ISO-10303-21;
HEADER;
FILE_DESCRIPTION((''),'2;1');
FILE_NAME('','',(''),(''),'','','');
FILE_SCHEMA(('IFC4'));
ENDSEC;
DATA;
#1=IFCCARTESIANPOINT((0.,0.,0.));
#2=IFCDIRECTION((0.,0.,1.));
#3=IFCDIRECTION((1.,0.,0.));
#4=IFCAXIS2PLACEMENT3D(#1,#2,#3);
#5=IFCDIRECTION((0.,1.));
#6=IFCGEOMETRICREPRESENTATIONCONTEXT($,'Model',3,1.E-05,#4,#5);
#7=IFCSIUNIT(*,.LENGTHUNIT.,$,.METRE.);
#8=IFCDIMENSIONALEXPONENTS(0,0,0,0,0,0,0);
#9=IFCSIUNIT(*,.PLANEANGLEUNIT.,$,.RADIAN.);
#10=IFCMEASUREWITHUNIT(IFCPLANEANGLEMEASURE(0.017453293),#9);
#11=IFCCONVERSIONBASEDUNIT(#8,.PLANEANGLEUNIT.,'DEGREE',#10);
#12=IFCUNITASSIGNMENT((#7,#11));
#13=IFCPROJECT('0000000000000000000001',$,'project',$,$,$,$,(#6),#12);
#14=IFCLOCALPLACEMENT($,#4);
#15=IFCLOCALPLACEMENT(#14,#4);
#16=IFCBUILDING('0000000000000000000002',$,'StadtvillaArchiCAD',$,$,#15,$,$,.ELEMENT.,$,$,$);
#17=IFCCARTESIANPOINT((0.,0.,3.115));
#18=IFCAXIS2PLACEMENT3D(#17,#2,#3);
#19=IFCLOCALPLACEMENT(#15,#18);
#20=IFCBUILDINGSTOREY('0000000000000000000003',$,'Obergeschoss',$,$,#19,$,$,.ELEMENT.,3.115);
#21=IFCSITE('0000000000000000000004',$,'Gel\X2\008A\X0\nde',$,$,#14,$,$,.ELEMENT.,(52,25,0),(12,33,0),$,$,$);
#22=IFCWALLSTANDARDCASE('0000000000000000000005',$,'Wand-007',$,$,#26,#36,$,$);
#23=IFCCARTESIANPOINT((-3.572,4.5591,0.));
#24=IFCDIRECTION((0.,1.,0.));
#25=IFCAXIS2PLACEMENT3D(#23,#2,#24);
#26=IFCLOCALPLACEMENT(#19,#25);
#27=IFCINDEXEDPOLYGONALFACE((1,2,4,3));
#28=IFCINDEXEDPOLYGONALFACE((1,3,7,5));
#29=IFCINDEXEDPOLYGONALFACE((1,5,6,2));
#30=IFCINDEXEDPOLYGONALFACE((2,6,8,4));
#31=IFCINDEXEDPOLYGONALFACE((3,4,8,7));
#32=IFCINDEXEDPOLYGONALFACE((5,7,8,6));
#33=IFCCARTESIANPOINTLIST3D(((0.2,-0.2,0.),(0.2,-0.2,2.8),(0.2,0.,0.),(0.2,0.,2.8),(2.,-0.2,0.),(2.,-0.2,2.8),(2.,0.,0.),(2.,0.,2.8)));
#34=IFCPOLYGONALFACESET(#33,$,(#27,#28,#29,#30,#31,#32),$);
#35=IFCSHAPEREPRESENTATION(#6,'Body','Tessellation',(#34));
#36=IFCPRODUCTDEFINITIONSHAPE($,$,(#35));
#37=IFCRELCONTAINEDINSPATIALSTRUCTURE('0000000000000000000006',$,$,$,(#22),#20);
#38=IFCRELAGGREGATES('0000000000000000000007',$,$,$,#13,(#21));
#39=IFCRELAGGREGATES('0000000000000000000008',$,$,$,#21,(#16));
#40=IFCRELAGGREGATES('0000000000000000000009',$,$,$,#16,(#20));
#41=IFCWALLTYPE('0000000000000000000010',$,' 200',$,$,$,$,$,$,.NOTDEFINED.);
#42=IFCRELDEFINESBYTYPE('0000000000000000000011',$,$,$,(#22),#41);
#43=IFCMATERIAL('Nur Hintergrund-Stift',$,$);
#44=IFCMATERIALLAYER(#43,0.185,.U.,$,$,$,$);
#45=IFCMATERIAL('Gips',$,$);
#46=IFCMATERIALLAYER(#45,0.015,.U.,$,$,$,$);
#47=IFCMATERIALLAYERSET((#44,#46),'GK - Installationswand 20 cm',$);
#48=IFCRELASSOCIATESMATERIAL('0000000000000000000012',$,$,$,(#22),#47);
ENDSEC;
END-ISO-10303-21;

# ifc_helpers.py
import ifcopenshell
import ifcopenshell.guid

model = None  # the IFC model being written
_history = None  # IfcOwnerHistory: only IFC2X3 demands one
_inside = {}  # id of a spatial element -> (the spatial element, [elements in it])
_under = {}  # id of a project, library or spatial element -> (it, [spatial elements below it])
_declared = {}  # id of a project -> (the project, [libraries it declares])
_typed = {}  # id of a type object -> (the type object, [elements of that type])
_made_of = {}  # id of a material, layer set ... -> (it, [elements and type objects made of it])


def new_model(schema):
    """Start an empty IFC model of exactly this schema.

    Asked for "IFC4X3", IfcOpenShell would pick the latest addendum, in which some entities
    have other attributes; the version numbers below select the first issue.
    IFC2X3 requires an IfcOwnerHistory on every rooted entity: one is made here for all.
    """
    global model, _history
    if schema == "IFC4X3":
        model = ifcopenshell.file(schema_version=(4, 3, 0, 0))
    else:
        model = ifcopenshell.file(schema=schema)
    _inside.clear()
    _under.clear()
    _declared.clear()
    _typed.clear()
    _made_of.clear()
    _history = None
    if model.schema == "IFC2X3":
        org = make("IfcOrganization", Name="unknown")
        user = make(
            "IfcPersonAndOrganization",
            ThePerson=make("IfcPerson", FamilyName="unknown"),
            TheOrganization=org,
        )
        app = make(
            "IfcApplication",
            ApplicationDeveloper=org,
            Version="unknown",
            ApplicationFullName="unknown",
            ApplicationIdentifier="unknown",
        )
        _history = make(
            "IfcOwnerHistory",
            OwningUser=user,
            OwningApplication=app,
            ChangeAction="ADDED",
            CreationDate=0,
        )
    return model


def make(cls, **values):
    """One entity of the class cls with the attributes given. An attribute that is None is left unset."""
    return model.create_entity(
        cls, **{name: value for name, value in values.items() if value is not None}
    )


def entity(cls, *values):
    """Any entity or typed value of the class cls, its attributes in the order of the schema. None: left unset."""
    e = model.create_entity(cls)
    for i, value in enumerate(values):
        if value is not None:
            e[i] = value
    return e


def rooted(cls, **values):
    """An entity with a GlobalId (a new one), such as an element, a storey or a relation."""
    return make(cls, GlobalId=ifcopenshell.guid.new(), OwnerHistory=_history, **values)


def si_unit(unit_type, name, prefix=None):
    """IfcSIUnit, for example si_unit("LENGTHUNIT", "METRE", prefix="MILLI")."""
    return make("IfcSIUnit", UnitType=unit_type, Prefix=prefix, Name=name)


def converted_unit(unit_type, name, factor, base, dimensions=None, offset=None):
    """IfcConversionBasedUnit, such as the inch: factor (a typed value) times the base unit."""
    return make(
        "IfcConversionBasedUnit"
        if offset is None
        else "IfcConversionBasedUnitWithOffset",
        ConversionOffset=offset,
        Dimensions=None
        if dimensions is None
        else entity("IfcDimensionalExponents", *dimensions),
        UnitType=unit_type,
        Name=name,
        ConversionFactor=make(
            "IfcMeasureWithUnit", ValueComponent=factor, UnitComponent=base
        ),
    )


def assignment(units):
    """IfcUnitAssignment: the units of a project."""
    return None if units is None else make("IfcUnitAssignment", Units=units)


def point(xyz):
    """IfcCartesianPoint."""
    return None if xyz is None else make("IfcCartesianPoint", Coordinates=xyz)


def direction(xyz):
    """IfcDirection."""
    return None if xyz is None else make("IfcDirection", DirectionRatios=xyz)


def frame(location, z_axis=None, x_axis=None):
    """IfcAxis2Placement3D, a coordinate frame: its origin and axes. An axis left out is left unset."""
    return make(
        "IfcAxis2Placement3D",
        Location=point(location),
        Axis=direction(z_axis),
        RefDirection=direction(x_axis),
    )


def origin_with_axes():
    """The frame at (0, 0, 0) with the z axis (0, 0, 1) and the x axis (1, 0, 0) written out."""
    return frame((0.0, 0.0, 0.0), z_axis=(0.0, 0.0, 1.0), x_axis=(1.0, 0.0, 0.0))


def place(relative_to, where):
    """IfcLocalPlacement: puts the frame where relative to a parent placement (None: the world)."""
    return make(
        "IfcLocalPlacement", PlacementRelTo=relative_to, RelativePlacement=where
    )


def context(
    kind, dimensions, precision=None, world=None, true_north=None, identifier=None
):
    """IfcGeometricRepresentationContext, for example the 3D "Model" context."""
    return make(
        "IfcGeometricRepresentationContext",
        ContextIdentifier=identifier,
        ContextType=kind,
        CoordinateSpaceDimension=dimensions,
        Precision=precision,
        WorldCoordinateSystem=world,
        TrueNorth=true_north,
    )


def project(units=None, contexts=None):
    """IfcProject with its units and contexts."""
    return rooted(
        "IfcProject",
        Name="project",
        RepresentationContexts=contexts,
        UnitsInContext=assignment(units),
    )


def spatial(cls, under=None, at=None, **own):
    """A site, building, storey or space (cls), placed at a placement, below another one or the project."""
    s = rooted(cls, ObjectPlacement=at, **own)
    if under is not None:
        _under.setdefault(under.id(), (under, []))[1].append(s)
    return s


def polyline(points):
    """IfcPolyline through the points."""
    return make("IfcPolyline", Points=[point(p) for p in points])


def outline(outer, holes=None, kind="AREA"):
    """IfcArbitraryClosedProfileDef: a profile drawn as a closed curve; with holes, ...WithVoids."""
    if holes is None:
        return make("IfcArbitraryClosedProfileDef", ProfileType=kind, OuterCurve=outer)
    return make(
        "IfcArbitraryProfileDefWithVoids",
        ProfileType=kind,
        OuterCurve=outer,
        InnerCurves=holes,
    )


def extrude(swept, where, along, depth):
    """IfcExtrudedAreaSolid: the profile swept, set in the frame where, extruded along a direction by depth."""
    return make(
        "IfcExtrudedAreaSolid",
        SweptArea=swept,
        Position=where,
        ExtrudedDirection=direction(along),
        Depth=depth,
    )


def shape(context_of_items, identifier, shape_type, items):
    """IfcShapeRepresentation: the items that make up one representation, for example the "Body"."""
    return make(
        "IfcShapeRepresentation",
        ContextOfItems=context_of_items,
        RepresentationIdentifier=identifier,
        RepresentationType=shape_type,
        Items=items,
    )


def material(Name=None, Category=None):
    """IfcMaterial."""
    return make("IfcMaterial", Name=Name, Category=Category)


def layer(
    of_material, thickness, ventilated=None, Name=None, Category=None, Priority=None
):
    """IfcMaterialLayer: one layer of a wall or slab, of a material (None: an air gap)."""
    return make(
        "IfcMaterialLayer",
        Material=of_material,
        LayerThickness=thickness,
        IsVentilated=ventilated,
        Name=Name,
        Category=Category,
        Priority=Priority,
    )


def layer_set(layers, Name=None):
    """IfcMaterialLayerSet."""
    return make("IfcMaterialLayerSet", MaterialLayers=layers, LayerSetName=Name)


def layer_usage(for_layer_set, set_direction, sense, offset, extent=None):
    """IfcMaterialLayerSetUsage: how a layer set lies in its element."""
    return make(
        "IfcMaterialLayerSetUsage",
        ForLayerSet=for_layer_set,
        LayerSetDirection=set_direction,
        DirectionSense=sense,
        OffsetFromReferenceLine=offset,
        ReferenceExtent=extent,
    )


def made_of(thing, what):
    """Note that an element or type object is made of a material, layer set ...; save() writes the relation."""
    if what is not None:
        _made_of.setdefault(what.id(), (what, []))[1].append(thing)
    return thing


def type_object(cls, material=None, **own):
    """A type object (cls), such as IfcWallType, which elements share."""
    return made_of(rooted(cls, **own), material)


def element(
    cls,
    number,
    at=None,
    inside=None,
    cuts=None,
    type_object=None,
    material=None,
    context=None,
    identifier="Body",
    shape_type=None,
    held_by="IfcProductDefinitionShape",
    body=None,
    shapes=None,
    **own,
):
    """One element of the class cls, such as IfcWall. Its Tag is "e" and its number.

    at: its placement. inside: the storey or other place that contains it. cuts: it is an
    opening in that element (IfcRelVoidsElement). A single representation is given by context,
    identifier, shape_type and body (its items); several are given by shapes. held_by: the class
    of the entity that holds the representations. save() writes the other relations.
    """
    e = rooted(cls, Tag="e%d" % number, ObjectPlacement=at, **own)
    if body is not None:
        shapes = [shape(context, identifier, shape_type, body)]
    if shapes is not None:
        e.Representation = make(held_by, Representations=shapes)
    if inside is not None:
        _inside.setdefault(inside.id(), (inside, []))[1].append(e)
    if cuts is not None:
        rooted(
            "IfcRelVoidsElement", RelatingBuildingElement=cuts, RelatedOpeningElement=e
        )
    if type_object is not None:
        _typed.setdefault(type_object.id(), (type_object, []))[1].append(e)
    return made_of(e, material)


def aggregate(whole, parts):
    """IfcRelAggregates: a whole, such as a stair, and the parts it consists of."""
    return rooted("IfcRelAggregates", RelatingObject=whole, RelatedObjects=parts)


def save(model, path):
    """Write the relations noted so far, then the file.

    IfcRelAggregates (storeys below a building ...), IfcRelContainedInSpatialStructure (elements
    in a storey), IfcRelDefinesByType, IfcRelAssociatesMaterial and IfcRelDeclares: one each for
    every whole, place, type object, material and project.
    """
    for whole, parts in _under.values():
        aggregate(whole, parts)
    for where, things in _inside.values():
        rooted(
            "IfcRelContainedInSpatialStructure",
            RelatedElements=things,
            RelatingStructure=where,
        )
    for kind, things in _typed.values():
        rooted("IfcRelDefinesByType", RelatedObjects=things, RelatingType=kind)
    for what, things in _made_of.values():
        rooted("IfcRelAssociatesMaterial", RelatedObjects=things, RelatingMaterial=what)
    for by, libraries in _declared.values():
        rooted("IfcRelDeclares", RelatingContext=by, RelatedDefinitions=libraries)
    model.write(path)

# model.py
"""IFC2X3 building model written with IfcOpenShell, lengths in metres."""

from ifc_helpers import new_model, entity, si_unit, converted_unit, direction, frame, origin_with_axes, place, context, project, spatial, polyline, outline, extrude, material, layer, layer_set, layer_usage, type_object, element, save


model = new_model("IFC2X3")

# Units and contexts
model_context = context("Model", 3, precision=1e-05, world=origin_with_axes(), true_north=direction((0.0, 1.0)))
ifc_project = project(units=[si_unit("LENGTHUNIT", "METRE"), converted_unit("PLANEANGLEUNIT", "DEGREE", entity("IfcPlaneAngleMeasure", 0.017453293), si_unit("PLANEANGLEUNIT", "RADIAN"), dimensions=[0, 0, 0, 0, 0, 0, 0])], contexts=[model_context])

# Site, building, storey
site_placement = place(None, origin_with_axes())
site = spatial("IfcSite", under=ifc_project, at=site_placement, Name="Gel\u008ande", CompositionType="ELEMENT", RefLatitude=(52, 25, 0), RefLongitude=(12, 33, 0))
building_placement = place(site_placement, origin_with_axes())
building = spatial("IfcBuilding", under=site, at=building_placement, Name="StadtvillaArchiCAD", CompositionType="ELEMENT")
storey_placement = place(building_placement, frame((0.0, 0.0, 3.115), z_axis=(0.0, 0.0, 1.0), x_axis=(1.0, 0.0, 0.0)))
storey = spatial("IfcBuildingStorey", under=building, at=storey_placement, Name="Obergeschoss", CompositionType="ELEMENT", Elevation=3.115)

# Wall
ifc_material_1 = material(Name="Nur Hintergrund-Stift")
ifc_layer_1 = layer(ifc_material_1, 0.185, ventilated="UNKNOWN")
ifc_material_2 = material(Name="Gips")
ifc_layer_2 = layer(ifc_material_2, 0.015, ventilated="UNKNOWN")
ifc_layer_set_1 = layer_set([ifc_layer_1, ifc_layer_2], Name="GK - Installationswand 20 cm")
ifc_layer_usage_1 = layer_usage(ifc_layer_set_1, "AXIS2", "NEGATIVE", 0.0)
wall_type_1 = type_object("IfcWallType", Name=" 200", PredefinedType="NOTDEFINED")
wall_1_placement = place(storey_placement, frame((-3.572, 4.5591, 0.0), z_axis=(0.0, 0.0, 1.0), x_axis=(0.0, 1.0, 0.0)))
element("IfcWallStandardCase", 1, at=wall_1_placement, inside=storey, type_object=wall_type_1, material=ifc_layer_usage_1, Name="Wand-007", context=model_context, shape_type="SweptSolid", body=[
    extrude(outline(polyline([(0.2, -0.2), (2.0, -0.2), (2.0, 0.0), (0.2, 0.0), (0.2, -0.2)])), origin_with_axes(), (0.0, 0.0, 1.0), 2.8),
])

save(model, "model.ifc")
